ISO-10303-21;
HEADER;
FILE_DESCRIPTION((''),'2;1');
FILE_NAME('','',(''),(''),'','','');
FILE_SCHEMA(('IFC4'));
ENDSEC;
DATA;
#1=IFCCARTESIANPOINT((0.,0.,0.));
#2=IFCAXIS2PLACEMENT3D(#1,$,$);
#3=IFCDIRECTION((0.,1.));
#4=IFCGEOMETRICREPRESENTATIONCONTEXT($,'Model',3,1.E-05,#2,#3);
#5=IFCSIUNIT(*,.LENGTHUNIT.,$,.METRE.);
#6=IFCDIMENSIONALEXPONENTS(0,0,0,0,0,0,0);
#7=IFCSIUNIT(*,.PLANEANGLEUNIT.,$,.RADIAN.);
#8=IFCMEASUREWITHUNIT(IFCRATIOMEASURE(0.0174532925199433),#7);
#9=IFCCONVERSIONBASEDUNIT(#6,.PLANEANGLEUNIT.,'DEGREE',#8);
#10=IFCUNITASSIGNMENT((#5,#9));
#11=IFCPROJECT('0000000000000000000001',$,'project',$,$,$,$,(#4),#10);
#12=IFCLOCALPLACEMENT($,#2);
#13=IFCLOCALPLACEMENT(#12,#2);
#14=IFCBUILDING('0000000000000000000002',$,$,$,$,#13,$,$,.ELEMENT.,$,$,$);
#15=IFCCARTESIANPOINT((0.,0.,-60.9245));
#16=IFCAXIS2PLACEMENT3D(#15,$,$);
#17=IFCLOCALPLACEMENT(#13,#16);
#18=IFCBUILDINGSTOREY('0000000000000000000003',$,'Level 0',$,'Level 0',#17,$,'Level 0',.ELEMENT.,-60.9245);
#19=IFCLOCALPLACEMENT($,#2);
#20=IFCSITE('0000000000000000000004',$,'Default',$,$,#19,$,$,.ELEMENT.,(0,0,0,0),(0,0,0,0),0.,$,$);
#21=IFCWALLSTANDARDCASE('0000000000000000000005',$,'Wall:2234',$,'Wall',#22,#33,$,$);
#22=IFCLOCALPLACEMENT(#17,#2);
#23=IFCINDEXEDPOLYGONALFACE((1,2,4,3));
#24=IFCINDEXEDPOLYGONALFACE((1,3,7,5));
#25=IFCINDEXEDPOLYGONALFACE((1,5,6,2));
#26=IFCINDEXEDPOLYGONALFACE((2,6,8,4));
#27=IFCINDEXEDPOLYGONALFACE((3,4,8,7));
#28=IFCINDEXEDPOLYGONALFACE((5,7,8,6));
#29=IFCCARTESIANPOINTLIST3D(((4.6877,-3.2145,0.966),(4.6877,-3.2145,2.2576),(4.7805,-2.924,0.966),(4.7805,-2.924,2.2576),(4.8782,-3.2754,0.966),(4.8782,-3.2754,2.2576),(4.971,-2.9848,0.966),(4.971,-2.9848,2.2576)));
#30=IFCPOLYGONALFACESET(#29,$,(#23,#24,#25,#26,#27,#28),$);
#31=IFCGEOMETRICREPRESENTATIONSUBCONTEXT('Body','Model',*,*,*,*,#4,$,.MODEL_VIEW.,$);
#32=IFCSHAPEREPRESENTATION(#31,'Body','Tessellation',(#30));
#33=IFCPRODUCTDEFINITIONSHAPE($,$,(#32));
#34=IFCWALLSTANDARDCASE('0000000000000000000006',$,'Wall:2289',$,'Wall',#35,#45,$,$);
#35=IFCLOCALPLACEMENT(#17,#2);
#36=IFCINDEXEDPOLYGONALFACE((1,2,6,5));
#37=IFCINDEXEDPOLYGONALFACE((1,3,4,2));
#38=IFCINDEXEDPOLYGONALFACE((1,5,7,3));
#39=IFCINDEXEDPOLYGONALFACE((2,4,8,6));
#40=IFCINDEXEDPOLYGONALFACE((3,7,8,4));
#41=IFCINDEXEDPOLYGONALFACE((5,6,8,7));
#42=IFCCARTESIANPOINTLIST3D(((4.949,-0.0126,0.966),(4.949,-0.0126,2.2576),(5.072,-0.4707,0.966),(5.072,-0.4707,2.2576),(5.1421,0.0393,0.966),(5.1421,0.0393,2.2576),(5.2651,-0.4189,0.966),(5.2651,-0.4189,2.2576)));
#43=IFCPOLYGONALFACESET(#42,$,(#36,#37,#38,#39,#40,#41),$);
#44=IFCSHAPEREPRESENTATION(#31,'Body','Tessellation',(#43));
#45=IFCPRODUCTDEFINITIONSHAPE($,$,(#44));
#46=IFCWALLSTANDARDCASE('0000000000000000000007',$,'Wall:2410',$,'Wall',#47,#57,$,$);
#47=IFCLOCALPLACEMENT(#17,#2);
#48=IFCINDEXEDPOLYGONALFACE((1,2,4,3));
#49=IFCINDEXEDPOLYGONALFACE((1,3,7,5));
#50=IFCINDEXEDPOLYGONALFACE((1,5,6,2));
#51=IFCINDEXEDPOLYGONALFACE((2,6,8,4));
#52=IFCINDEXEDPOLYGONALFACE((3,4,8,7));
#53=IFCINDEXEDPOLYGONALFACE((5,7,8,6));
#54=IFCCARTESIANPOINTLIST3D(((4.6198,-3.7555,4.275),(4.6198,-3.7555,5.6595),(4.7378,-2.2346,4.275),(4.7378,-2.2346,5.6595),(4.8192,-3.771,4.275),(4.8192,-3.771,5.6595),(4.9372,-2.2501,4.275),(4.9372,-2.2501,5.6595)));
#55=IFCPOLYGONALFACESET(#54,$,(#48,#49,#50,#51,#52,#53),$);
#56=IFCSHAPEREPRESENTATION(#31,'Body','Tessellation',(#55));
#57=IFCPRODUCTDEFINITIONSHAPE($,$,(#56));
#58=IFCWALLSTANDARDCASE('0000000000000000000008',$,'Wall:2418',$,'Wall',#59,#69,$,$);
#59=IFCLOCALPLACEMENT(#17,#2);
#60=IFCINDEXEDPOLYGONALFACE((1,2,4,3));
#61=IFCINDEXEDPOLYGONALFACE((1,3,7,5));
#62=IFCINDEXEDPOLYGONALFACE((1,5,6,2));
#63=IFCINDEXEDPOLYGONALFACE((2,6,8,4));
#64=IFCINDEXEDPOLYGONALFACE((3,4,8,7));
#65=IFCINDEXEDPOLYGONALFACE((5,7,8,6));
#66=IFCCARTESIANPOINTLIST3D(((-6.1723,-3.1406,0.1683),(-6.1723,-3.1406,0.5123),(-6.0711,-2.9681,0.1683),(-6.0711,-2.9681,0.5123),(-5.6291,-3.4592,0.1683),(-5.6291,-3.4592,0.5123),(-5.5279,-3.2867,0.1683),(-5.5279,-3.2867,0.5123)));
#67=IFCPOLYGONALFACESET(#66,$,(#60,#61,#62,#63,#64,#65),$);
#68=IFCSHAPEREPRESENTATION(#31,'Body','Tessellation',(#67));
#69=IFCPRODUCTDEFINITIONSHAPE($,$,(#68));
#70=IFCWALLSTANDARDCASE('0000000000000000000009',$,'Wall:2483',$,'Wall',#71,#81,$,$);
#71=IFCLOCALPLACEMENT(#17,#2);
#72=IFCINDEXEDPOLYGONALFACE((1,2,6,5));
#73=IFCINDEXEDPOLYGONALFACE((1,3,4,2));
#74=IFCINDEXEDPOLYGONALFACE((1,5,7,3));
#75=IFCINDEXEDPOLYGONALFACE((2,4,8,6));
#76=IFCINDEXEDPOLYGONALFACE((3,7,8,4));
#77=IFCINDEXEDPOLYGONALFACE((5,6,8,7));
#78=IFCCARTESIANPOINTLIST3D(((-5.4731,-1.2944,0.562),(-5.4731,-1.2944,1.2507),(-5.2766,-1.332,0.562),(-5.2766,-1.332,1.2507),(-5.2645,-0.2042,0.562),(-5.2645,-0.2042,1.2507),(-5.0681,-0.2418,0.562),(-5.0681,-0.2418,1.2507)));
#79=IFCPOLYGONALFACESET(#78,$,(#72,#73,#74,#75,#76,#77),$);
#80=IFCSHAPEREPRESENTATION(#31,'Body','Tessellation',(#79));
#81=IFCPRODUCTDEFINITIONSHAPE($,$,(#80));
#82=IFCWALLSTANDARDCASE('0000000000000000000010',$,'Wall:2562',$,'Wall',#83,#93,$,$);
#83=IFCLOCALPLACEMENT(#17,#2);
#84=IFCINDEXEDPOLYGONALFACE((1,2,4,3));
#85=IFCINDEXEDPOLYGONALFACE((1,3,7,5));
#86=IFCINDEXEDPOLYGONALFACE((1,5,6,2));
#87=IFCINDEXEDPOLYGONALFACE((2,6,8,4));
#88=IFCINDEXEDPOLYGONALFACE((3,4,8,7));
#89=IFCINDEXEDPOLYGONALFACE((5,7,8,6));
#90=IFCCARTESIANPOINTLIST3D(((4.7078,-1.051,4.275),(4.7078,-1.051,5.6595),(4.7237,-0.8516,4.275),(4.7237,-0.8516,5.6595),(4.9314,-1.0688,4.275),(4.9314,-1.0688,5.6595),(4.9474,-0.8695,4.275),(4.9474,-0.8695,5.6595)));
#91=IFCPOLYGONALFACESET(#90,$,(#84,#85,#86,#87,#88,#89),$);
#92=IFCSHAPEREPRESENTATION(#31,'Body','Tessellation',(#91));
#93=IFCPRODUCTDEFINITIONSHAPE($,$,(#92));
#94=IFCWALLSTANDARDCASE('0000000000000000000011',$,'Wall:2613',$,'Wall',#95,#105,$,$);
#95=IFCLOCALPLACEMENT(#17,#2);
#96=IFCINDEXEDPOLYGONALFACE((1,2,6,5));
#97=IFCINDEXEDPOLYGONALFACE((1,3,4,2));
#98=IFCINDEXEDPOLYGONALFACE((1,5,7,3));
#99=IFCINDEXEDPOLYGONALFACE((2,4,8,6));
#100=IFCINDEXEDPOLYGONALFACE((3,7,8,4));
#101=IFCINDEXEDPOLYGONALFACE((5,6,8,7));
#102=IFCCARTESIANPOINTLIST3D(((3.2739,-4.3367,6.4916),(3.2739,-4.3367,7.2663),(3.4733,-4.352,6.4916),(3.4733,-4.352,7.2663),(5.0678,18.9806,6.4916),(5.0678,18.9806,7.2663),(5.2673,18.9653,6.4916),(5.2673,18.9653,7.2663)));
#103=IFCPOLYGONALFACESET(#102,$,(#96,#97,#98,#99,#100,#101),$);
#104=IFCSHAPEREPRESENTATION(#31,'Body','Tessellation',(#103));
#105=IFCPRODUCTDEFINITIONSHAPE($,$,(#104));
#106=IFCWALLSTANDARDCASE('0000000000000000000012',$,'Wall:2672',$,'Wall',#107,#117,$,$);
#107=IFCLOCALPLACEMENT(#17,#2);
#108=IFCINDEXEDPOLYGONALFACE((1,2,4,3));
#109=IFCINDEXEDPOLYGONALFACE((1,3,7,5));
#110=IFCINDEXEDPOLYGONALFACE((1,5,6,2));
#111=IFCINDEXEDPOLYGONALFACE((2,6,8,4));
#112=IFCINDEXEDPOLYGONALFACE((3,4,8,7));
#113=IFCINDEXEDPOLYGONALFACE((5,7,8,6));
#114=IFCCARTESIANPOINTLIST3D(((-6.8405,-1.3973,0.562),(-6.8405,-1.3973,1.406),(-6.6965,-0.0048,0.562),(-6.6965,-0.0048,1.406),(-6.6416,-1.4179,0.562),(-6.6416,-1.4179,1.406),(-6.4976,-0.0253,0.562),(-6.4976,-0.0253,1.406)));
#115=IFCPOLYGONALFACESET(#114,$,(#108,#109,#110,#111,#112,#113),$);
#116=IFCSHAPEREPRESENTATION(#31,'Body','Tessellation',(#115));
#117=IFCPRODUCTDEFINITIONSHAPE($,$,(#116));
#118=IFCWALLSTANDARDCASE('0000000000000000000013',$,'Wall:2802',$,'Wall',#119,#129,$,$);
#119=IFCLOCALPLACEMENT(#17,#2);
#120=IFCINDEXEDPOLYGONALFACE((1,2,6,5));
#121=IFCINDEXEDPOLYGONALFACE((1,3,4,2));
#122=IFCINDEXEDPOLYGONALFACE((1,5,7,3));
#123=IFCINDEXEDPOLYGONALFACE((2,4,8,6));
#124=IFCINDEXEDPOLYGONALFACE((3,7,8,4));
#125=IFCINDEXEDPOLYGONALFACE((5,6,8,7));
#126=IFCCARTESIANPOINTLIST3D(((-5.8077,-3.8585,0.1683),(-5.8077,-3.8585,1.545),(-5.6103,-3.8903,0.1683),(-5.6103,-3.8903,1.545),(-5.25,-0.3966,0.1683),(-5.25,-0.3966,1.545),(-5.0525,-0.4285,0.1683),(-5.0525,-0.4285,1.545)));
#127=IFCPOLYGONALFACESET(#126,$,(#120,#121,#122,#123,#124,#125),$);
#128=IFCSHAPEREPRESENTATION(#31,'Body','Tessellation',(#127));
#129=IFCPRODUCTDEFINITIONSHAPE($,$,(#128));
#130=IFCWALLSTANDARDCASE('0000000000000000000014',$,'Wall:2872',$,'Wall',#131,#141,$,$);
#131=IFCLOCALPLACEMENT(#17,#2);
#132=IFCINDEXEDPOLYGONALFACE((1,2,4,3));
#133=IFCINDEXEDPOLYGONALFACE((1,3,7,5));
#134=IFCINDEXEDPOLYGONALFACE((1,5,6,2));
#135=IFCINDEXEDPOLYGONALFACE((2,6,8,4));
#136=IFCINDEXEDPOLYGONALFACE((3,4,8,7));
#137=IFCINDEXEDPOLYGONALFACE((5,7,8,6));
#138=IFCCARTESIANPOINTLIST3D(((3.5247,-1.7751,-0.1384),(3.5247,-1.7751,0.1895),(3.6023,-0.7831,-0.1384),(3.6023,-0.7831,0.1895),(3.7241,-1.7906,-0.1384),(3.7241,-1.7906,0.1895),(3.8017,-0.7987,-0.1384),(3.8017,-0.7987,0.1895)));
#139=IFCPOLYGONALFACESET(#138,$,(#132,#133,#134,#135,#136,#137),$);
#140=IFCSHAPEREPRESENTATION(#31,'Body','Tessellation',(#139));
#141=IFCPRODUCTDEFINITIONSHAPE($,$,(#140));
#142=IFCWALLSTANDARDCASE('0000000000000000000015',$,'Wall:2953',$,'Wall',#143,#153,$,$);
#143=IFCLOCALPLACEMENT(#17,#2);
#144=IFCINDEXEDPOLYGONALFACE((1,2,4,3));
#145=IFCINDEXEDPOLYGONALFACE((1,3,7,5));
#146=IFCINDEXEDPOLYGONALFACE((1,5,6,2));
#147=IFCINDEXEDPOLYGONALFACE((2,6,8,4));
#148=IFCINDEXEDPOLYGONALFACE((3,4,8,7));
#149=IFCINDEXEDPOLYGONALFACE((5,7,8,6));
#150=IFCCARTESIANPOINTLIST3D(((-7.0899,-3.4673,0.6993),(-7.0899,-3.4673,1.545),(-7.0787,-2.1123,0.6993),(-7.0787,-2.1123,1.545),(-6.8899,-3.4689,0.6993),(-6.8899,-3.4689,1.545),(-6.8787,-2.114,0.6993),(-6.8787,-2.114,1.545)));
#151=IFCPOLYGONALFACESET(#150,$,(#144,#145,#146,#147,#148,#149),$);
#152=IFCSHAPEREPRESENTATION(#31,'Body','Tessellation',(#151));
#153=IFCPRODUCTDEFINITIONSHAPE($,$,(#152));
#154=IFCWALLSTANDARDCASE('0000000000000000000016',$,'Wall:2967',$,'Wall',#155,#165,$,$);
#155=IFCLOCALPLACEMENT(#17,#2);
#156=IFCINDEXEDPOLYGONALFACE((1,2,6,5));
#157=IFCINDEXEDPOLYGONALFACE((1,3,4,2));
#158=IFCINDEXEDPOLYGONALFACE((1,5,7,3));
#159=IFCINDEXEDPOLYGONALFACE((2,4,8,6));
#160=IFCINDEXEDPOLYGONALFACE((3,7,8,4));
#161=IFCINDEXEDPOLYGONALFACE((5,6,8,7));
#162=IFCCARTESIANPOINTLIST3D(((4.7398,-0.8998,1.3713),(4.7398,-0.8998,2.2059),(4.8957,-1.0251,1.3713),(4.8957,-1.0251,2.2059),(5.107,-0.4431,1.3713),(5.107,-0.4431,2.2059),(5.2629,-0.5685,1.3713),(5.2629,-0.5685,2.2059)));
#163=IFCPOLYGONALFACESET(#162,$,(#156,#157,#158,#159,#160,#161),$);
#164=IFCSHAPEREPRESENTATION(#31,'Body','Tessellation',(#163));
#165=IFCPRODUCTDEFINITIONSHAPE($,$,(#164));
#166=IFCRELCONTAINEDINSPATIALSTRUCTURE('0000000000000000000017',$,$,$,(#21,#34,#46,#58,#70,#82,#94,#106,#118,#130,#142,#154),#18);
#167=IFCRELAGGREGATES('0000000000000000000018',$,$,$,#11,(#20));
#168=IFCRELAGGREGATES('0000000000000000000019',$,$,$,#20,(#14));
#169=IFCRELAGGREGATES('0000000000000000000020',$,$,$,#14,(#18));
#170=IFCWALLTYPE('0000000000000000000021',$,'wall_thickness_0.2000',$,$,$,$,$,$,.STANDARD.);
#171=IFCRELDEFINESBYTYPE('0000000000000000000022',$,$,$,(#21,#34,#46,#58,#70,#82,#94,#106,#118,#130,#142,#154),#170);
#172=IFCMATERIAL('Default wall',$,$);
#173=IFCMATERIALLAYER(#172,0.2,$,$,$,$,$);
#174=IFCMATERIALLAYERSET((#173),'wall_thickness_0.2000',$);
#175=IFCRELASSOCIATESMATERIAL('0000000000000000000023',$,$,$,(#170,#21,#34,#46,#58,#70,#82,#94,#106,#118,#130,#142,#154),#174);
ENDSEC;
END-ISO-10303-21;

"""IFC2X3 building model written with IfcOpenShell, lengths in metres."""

from ifc_helpers import new_model, entity, si_unit, converted_unit, direction, frame, origin, place, context, subcontext, project, spatial, polyline, outline, extrude, material, layer, layer_set, layer_usage, type_object, element, save


model = new_model("IFC2X3")

# Units and contexts
model_context = context("Model", 3, precision=1e-05, world=origin(), true_north=direction((0.0, 1.0)))
body_context = subcontext(model_context, "Body", "Model", "MODEL_VIEW")
ifc_project = project(units=[si_unit("LENGTHUNIT", "METRE"), converted_unit("PLANEANGLEUNIT", "DEGREE", entity("IfcRatioMeasure", 0.0174532925199433), si_unit("PLANEANGLEUNIT", "RADIAN"), dimensions=[0, 0, 0, 0, 0, 0, 0])], contexts=[model_context])

# Site, building, storey
site_placement = place(None, origin())
site = spatial("IfcSite", under=ifc_project, at=site_placement, Name="Default", CompositionType="ELEMENT", RefLatitude=(0, 0, 0, 0), RefLongitude=(0, 0, 0, 0), RefElevation=0.0)
placement_1 = place(None, origin())
building_placement = place(placement_1, origin())
building = spatial("IfcBuilding", under=site, at=building_placement, CompositionType="ELEMENT")
storey_placement = place(building_placement, frame((0.0, 0.0, -60.9245)))
storey = spatial("IfcBuildingStorey", under=building, at=storey_placement, Name="Level 0", ObjectType="Level 0", LongName="Level 0", CompositionType="ELEMENT", Elevation=-60.9245)

# Walls
ifc_material = material(Name="Default wall")
ifc_layer = layer(ifc_material, 0.2)
ifc_layer_set = layer_set([ifc_layer], Name="wall_thickness_0.2000")
ifc_layer_usage = layer_usage(ifc_layer_set, "AXIS2", "POSITIVE", -0.1)
wall_type = type_object("IfcWallType", Name="wall_thickness_0.2000", PredefinedType="STANDARD", material=ifc_layer_set)
placement_2 = place(building_placement, frame((0.0, 0.0, -59.9585)))
wall_1_placement = place(placement_2, frame((4.8758, -2.9544, 0.0), z_axis=(0.0, 0.0, 1.0), x_axis=(-0.30428, -0.952583, 0.0)))
element("IfcWallStandardCase", 1, at=wall_1_placement, inside=storey, type_object=wall_type, material=ifc_layer_usage, Name="Wall:2234", ObjectType="Wall", context=body_context, shape_type="SweptSolid", body=[
    extrude(outline(polyline([(0.305, -0.1), (0.305, 0.1), (0.0, 0.1), (0.0, -0.1), (0.305, -0.1)])), origin(), (0.0, 0.0, 1.0), 1.2916),
])
placement_3 = place(building_placement, frame((0.0, 0.0, -59.9585)))
wall_2_placement = place(placement_3, frame((5.1686, -0.4448, 0.0), z_axis=(0.0, 0.0, 1.0), x_axis=(-0.259255, 0.965809, 0.0)))
element("IfcWallStandardCase", 2, at=wall_2_placement, inside=storey, type_object=wall_type, material=ifc_layer_usage, Name="Wall:2289", ObjectType="Wall", context=body_context, shape_type="SweptSolid", body=[
    extrude(outline(polyline([(0.4744, -0.1), (0.4744, 0.1), (0.0, 0.1), (0.0, -0.1), (0.4744, -0.1)])), origin(), (0.0, 0.0, 1.0), 1.2916),
])
placement_4 = place(building_placement, frame((0.0, 0.0, -56.6495)))
wall_3_placement = place(placement_4, frame((4.8375, -2.2424, 0.0), z_axis=(0.0, 0.0, 1.0), x_axis=(-0.077362, -0.997003, 0.0)))
element("IfcWallStandardCase", 3, at=wall_3_placement, inside=storey, type_object=wall_type, material=ifc_layer_usage, Name="Wall:2410", ObjectType="Wall", context=body_context, shape_type="SweptSolid", body=[
    extrude(outline(polyline([(1.5254, -0.1), (1.5254, 0.1), (0.0, 0.1), (0.0, -0.1), (1.5254, -0.1)])), origin(), (0.0, 0.0, 1.0), 1.3845),
])
placement_5 = place(building_placement, frame((0.0, 0.0, -60.7562)))
wall_4_placement = place(placement_5, frame((-6.1217, -3.0544, 0.0), z_axis=(0.0, 0.0, 1.0), x_axis=(0.86258, -0.50592, 0.0)))
element("IfcWallStandardCase", 4, at=wall_4_placement, inside=storey, type_object=wall_type, material=ifc_layer_usage, Name="Wall:2418", ObjectType="Wall", context=body_context, shape_type="SweptSolid", body=[
    extrude(outline(polyline([(0.6297, -0.1), (0.6297, 0.1), (0.0, 0.1), (0.0, -0.1), (0.6297, -0.1)])), origin(), (0.0, 0.0, 1.0), 0.3439),
])
placement_6 = place(building_placement, frame((0.0, 0.0, -60.3625)))
wall_5_placement = place(placement_6, frame((-5.3748, -1.3132, 0.0), z_axis=(0.0, 0.0, 1.0), x_axis=(0.187895, 0.982189, 0.0)))
element("IfcWallStandardCase", 5, at=wall_5_placement, inside=storey, type_object=wall_type, material=ifc_layer_usage, Name="Wall:2483", ObjectType="Wall", context=body_context, shape_type="SweptSolid", body=[
    extrude(outline(polyline([(1.11, -0.1), (1.11, 0.1), (0.0, 0.1), (0.0, -0.1), (1.11, -0.1)])), origin(), (0.0, 0.0, 1.0), 0.6887),
])
placement_7 = place(building_placement, frame((0.0, 0.0, -56.6495)))
wall_6_placement = place(placement_7, frame((4.9394, -0.9691, 0.0), z_axis=(0.0, 0.0, 1.0), x_axis=(-0.996833, 0.079527, 0.0)))
element("IfcWallStandardCase", 6, at=wall_6_placement, inside=storey, type_object=wall_type, material=ifc_layer_usage, Name="Wall:2562", ObjectType="Wall", context=body_context, shape_type="SweptSolid", body=[
    extrude(outline(polyline([(0.2244, -0.1), (0.2244, 0.1), (0.0, 0.1), (0.0, -0.1), (0.2244, -0.1)])), origin(), (0.0, 0.0, 1.0), 1.3845),
])
placement_8 = place(building_placement, frame((0.0, 0.0, -54.4329)))
wall_7_placement = place(placement_8, frame((3.3736, -4.3444, 0.0), z_axis=(0.0, 0.0, 1.0), x_axis=(0.076708, 0.997054, 0.0)))
element("IfcWallStandardCase", 7, at=wall_7_placement, inside=storey, type_object=wall_type, material=ifc_layer_usage, Name="Wall:2613", ObjectType="Wall", context=body_context, shape_type="SweptSolid", body=[
    extrude(outline(polyline([(23.3862, -0.1), (23.3862, 0.1), (0.0, 0.1), (0.0, -0.1), (23.3862, -0.1)])), origin(), (0.0, 0.0, 1.0), 0.7746),
])
placement_9 = place(building_placement, frame((0.0, 0.0, -60.3625)))
wall_8_placement = place(placement_9, frame((-6.7411, -1.4076, 0.0), z_axis=(0.0, 0.0, 1.0), x_axis=(0.102873, 0.994695, 0.0)))
element("IfcWallStandardCase", 8, at=wall_8_placement, inside=storey, type_object=wall_type, material=ifc_layer_usage, Name="Wall:2672", ObjectType="Wall", context=body_context, shape_type="SweptSolid", body=[
    extrude(outline(polyline([(1.4, -0.1), (1.4, 0.1), (0.0, 0.1), (0.0, -0.1), (1.4, -0.1)])), origin(), (0.0, 0.0, 1.0), 0.8441),
])
placement_10 = place(building_placement, frame((0.0, 0.0, -60.7562)))
wall_9_placement = place(placement_10, frame((-5.709, -3.8744, 0.0), z_axis=(0.0, 0.0, 1.0), x_axis=(0.159058, 0.987269, 0.0)))
element("IfcWallStandardCase", 9, at=wall_9_placement, inside=storey, type_object=wall_type, material=ifc_layer_usage, Name="Wall:2802", ObjectType="Wall", context=body_context, shape_type="SweptSolid", body=[
    extrude(outline(polyline([(3.5065, -0.1), (3.5065, 0.1), (0.0, 0.1), (0.0, -0.1), (3.5065, -0.1)])), origin(), (0.0, 0.0, 1.0), 1.3767),
])
placement_11 = place(building_placement, frame((0.0, 0.0, -61.0629)))
wall_10_placement = place(placement_11, frame((3.6244, -1.7828, 0.0), z_axis=(0.0, 0.0, 1.0), x_axis=(0.077916, 0.99696, 0.0)))
element("IfcWallStandardCase", 10, at=wall_10_placement, inside=storey, type_object=wall_type, material=ifc_layer_usage, Name="Wall:2872", ObjectType="Wall", context=body_context, shape_type="SweptSolid", body=[
    extrude(outline(polyline([(0.995, -0.1), (0.995, 0.1), (0.0, 0.1), (0.0, -0.1), (0.995, -0.1)])), origin(), (0.0, 0.0, 1.0), 0.3279),
])
placement_12 = place(building_placement, frame((0.0, 0.0, -60.2252)))
wall_11_placement = place(placement_12, frame((-6.9899, -3.4681, 0.0), z_axis=(0.0, 0.0, 1.0), x_axis=(0.008272, 0.999966, 0.0)))
element("IfcWallStandardCase", 11, at=wall_11_placement, inside=storey, type_object=wall_type, material=ifc_layer_usage, Name="Wall:2953", ObjectType="Wall", context=body_context, shape_type="SweptSolid", body=[
    extrude(outline(polyline([(1.355, -0.1), (1.355, 0.1), (0.0, 0.1), (0.0, -0.1), (1.355, -0.1)])), origin(), (0.0, 0.0, 1.0), 0.8457),
])
placement_13 = place(building_placement, frame((0.0, 0.0, -59.5532)))
wall_12_placement = place(placement_13, frame((5.1849, -0.5058, 0.0), z_axis=(0.0, 0.0, 1.0), x_axis=(-0.626571, -0.779365, 0.0)))
element("IfcWallStandardCase", 12, at=wall_12_placement, inside=storey, type_object=wall_type, material=ifc_layer_usage, Name="Wall:2967", ObjectType="Wall", context=body_context, shape_type="SweptSolid", body=[
    extrude(outline(polyline([(0.586, -0.1), (0.586, 0.1), (0.0, 0.1), (0.0, -0.1), (0.586, -0.1)])), origin(), (0.0, 0.0, 1.0), 0.8346),
])

save(model, "model.ifc")
